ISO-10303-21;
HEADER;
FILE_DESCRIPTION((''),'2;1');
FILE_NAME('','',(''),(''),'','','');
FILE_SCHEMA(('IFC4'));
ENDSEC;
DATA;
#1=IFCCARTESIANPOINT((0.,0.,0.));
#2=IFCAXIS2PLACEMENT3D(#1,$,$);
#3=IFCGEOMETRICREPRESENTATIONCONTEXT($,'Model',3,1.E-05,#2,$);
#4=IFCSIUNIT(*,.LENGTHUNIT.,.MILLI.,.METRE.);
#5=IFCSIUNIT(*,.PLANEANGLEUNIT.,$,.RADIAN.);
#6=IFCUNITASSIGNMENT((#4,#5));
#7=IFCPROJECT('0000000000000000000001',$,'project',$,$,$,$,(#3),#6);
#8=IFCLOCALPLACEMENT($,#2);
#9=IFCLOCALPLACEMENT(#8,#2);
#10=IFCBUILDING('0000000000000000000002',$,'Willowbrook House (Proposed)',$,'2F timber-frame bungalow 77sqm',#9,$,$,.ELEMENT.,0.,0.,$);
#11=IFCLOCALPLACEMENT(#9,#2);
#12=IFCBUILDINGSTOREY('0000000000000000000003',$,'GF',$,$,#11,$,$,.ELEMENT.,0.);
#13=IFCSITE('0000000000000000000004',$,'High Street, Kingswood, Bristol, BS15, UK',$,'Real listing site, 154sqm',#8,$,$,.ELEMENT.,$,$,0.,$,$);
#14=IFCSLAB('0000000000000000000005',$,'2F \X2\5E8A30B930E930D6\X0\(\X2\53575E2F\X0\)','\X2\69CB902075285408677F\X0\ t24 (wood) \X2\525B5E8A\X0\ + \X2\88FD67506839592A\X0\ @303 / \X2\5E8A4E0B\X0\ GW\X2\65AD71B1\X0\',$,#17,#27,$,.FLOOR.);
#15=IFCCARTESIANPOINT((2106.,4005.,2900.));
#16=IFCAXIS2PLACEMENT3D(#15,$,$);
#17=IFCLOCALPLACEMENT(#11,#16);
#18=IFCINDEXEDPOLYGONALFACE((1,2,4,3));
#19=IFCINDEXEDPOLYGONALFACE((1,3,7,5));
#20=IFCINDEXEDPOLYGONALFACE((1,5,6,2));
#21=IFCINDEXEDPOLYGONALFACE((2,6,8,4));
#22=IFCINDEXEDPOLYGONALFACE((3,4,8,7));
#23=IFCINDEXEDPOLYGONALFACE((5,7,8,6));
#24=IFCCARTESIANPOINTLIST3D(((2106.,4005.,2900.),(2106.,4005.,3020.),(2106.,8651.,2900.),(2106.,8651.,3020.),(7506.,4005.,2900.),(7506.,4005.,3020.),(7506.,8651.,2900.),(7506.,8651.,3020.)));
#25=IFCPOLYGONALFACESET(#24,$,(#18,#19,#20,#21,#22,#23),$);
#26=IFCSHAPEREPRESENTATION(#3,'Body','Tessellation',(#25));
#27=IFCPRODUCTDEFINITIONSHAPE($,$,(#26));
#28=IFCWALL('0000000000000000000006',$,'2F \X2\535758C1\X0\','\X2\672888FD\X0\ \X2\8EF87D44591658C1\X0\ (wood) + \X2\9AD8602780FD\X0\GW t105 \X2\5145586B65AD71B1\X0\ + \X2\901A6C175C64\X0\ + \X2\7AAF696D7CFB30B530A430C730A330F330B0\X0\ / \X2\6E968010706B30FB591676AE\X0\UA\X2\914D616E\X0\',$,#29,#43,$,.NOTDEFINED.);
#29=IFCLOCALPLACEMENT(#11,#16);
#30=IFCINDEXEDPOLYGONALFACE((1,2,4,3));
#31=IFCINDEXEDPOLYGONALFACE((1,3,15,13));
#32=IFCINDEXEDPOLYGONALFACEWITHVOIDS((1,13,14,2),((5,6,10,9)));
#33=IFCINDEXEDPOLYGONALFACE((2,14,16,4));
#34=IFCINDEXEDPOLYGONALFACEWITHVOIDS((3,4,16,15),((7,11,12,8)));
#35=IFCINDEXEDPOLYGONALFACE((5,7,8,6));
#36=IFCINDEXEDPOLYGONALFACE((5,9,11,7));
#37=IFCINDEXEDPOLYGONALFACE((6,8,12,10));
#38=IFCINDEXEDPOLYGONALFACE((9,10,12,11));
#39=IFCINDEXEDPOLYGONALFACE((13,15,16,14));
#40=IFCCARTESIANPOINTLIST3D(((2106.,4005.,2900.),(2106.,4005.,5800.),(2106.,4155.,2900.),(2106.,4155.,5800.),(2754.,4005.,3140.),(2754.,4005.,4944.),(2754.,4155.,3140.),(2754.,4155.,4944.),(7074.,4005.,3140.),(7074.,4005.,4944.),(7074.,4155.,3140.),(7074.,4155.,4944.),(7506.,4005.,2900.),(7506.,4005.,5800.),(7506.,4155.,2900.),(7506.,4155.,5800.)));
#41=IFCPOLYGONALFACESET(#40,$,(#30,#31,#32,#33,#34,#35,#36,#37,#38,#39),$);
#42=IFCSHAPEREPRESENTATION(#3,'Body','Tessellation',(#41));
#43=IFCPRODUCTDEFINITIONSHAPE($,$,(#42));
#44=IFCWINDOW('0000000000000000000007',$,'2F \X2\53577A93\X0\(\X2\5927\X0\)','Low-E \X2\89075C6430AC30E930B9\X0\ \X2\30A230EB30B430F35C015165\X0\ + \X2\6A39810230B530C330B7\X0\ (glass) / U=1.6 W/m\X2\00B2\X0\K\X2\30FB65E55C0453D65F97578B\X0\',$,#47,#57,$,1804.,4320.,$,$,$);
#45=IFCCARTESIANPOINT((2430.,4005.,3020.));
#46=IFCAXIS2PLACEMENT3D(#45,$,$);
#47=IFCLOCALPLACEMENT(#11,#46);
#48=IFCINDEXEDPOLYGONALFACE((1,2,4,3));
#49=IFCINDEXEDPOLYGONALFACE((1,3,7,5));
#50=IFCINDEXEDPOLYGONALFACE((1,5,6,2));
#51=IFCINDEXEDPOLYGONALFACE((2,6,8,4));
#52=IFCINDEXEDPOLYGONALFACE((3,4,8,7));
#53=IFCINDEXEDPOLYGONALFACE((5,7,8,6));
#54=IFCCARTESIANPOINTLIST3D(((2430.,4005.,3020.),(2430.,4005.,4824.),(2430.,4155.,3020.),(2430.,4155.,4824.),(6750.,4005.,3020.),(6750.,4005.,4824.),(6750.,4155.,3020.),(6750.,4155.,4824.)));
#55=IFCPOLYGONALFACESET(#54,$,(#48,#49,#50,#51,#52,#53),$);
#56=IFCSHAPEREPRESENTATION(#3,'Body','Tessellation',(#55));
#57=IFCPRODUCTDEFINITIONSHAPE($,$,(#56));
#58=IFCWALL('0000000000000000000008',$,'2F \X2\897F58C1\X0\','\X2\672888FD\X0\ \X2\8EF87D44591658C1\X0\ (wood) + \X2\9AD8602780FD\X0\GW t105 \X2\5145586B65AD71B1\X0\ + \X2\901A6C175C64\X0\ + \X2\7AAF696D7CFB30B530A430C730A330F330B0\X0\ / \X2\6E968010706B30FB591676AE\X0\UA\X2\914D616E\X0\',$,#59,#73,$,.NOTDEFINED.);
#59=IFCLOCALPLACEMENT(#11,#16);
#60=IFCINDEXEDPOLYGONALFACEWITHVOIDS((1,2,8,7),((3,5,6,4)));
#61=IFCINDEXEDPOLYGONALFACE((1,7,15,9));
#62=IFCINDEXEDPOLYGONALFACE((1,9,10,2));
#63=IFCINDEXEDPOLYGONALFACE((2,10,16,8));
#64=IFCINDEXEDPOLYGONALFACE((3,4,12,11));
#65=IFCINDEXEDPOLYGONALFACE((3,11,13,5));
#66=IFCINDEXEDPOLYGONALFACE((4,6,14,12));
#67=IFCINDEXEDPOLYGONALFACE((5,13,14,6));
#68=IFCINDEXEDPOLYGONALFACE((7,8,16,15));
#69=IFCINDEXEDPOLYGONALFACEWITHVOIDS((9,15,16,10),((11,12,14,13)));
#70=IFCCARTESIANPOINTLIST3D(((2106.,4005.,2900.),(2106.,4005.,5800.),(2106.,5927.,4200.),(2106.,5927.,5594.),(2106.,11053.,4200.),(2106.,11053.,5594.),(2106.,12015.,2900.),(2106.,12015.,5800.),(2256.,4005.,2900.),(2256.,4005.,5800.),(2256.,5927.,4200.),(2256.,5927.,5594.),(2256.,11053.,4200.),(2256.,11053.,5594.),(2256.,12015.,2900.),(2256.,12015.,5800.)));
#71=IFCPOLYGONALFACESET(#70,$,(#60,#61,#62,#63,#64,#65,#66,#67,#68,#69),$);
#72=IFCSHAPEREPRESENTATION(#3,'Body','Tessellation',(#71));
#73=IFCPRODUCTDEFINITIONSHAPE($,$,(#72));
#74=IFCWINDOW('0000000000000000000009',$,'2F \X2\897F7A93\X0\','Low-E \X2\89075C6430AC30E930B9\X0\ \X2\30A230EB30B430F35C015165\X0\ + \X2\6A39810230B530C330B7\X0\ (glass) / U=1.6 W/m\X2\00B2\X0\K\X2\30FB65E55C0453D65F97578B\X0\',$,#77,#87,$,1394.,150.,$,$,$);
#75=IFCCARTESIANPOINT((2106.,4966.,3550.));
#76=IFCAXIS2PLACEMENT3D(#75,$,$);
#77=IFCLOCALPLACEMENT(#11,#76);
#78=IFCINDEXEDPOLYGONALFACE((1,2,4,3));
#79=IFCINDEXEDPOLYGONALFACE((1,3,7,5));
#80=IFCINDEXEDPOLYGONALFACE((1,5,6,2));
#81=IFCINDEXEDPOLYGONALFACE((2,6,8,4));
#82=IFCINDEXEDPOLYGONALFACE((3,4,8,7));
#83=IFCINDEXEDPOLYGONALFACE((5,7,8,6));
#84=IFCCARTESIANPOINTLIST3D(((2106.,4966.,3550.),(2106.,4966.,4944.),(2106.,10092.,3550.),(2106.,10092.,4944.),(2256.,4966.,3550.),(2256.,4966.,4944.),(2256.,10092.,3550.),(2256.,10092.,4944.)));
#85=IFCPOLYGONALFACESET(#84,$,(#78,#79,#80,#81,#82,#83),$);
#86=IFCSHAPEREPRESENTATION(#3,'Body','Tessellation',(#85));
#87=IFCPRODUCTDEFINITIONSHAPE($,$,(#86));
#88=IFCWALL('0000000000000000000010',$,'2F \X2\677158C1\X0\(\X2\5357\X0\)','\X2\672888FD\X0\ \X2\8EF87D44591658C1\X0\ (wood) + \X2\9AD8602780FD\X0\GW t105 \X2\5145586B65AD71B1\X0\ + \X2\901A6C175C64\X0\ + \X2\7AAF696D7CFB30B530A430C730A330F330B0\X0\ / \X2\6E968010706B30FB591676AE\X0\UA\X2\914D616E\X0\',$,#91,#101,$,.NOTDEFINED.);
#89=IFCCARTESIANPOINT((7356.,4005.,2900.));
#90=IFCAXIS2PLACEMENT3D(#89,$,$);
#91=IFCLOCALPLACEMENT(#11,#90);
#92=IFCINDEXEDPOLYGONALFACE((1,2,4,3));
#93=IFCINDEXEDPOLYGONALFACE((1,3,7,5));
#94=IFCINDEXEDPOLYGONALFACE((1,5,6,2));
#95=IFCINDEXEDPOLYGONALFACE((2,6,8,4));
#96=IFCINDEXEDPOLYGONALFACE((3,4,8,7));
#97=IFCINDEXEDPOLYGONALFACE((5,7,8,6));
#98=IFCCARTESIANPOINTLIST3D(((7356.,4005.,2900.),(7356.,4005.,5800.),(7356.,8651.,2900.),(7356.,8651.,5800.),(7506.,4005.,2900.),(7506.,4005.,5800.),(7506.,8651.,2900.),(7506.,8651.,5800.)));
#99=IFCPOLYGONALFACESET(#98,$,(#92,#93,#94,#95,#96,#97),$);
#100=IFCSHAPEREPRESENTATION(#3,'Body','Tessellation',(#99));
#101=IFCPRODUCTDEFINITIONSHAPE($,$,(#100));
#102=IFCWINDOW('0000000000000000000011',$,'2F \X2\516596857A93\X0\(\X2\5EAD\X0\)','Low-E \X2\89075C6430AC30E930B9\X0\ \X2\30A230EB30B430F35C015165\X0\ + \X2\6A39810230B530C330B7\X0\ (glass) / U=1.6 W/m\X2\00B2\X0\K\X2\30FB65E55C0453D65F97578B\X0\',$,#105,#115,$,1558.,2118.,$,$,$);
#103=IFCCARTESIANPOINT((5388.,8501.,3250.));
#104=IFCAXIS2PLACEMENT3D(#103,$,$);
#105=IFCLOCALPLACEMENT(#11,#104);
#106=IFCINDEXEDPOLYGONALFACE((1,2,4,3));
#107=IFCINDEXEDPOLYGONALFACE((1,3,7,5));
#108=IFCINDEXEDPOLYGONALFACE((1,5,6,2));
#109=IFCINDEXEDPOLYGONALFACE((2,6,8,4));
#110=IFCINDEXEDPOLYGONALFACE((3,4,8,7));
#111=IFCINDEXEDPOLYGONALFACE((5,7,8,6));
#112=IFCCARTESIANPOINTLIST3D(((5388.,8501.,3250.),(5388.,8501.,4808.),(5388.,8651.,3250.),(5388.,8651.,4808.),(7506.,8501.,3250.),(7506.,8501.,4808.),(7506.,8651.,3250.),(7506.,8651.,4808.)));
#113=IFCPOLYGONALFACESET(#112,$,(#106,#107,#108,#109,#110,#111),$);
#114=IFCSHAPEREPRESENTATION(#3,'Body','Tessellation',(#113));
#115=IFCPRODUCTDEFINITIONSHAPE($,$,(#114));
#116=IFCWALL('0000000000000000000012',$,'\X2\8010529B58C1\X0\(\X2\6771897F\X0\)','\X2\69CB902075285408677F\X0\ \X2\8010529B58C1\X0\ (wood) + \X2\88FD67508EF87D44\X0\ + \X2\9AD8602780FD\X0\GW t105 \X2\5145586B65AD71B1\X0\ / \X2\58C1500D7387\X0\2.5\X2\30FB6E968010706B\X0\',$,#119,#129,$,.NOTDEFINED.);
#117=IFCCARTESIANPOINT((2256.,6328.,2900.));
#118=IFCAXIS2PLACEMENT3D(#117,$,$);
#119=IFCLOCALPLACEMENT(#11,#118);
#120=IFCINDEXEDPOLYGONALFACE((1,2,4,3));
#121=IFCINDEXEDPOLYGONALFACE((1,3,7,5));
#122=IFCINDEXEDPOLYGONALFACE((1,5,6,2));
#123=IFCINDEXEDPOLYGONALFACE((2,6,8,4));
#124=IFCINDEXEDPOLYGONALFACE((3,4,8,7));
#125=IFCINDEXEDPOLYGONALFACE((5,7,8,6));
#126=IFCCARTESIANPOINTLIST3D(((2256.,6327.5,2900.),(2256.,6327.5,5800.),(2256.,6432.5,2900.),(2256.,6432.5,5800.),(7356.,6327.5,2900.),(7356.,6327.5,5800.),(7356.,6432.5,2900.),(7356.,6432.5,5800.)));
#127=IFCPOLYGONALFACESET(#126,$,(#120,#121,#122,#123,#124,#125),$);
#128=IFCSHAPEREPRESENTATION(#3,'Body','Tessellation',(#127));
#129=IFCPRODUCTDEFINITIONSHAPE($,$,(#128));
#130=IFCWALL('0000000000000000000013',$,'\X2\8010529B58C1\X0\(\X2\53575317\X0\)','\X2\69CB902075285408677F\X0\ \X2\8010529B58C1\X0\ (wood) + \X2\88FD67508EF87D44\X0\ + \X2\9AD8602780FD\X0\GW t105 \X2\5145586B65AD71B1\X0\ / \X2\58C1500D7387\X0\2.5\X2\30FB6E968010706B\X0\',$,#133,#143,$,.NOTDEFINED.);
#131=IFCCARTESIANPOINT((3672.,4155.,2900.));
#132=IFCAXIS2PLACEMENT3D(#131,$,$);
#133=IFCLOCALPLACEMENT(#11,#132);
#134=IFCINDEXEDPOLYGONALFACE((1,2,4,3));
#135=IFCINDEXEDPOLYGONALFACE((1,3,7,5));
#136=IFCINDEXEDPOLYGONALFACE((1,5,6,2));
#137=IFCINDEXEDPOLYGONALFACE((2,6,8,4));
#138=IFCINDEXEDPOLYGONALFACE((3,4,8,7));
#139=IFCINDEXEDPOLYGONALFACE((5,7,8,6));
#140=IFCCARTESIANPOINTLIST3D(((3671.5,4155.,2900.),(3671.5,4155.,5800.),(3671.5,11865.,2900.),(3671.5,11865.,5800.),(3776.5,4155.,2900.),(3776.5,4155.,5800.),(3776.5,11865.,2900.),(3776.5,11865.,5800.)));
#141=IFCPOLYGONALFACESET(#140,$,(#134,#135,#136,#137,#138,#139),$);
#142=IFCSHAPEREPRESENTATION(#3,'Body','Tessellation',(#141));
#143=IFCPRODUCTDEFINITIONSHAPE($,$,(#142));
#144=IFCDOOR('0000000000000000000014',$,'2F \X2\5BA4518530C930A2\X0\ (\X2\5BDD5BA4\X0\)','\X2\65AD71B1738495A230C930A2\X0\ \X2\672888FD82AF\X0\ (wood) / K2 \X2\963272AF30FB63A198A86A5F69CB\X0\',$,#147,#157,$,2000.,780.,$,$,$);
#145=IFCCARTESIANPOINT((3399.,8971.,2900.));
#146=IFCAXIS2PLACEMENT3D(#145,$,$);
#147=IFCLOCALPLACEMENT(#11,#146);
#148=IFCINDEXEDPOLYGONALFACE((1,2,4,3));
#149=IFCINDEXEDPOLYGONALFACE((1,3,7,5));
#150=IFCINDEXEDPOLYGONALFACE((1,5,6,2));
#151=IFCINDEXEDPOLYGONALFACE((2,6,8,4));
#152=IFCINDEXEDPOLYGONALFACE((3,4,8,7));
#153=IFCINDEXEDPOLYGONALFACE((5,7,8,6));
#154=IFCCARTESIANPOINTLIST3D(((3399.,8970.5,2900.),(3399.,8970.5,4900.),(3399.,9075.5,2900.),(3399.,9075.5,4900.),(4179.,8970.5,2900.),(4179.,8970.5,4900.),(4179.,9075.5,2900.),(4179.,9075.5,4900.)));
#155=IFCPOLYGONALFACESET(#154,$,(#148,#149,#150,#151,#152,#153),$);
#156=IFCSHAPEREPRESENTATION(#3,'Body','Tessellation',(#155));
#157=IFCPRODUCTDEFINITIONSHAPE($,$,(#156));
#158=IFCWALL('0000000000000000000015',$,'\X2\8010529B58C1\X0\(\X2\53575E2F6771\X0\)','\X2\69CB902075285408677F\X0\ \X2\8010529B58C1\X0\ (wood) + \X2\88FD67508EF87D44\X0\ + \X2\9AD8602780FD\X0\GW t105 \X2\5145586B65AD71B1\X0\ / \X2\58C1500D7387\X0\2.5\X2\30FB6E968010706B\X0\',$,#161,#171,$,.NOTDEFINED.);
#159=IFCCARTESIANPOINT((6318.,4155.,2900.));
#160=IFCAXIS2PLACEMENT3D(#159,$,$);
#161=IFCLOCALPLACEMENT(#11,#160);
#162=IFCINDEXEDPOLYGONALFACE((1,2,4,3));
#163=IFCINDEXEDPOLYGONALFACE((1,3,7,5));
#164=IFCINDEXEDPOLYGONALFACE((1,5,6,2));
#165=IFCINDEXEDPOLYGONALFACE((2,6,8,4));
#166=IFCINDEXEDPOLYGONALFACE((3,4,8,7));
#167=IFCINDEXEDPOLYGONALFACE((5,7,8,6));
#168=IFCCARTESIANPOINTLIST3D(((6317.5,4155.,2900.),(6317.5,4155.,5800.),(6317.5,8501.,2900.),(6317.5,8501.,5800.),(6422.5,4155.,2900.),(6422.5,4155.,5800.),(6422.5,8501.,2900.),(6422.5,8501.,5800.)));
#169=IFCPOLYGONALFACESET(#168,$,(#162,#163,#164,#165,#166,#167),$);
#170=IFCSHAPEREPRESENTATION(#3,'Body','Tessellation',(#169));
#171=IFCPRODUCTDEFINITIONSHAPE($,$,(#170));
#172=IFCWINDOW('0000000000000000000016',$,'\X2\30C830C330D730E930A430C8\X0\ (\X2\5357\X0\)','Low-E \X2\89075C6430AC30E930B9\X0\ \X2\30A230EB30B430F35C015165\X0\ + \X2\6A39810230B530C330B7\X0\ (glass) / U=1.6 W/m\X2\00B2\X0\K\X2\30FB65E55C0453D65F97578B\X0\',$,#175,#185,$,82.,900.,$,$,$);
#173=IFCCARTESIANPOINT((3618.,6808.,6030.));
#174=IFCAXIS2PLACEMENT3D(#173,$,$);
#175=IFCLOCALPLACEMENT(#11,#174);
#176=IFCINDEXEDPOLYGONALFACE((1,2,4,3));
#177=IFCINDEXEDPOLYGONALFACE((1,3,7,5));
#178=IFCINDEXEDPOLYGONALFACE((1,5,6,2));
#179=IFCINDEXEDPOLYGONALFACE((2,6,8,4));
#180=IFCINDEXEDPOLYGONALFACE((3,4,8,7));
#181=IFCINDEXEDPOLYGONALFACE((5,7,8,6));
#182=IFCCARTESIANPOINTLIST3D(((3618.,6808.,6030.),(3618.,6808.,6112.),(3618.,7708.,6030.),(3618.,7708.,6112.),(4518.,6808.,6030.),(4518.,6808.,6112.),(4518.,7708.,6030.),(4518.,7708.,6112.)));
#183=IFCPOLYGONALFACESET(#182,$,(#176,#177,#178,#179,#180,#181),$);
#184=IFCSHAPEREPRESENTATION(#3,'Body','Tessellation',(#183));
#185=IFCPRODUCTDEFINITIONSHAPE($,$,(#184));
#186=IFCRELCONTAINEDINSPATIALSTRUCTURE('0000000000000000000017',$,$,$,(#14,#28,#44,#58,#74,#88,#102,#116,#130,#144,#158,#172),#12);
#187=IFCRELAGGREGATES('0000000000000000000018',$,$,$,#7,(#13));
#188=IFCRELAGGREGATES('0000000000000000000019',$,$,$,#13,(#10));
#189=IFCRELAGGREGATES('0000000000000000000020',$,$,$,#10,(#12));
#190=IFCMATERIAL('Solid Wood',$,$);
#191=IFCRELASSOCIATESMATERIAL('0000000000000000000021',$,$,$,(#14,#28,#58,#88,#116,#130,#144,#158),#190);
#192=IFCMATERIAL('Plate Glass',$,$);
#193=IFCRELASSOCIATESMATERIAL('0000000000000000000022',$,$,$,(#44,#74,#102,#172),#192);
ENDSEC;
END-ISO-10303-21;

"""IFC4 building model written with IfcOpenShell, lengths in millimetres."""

from ifc_helpers import new_model, si_unit, frame, frame_2d, origin, place, context, project, spatial, rectangle, extrude, material, element, fill, save


model = new_model("IFC4")

# Units and contexts
model_context = context("Model", 3, precision=1e-05, world=origin())
ifc_project = project(units=[si_unit("LENGTHUNIT", "METRE", prefix="MILLI"), si_unit("PLANEANGLEUNIT", "RADIAN")], contexts=[model_context])

# Site, building, storey
site_placement = place(None, origin())
site = spatial("IfcSite", under=ifc_project, at=site_placement, Name="High Street, Kingswood, Bristol, BS15, UK", ObjectType="Real listing site, 154sqm", CompositionType="ELEMENT", RefElevation=0.0)
building_placement = place(site_placement, origin())
building = spatial("IfcBuilding", under=site, at=building_placement, Name="Willowbrook House (Proposed)", ObjectType="2F timber-frame bungalow 77sqm", CompositionType="ELEMENT", ElevationOfRefHeight=0.0, ElevationOfTerrain=0.0)
storey_placement = place(building_placement, origin())
storey = spatial("IfcBuildingStorey", under=building, at=storey_placement, Name="GF", CompositionType="ELEMENT", Elevation=0.0)

# Slab
ifc_material_1 = material(Name="Solid Wood")
slab_placement = place(storey_placement, frame((2106.0, 4005.0, 2900.0)))
element("IfcSlab", 1, at=slab_placement, inside=storey, material=ifc_material_1, Name="2F 床スラブ(南帯)", Description="構造用合板 t24 (wood) 剛床 + 製材根太 @303 / 床下 GW断熱", PredefinedType="FLOOR", context=model_context, shape_type="SweptSolid", body=[
    extrude(rectangle(XDim=5400.0, YDim=4646.0, at=frame_2d((2700.0, 2323.0))), frame((2106.0, 4005.0, 2900.0)), (0.0, 0.0, 1.0), 120.0),
])

# Walls, openings, windows
wall_1_placement = place(storey_placement, frame((2106.0, 4005.0, 2900.0)))
wall_1 = element("IfcWall", 2, at=wall_1_placement, inside=storey, material=ifc_material_1, Name="2F 南壁", Description="木製 軸組外壁 (wood) + 高性能GW t105 充填断熱 + 通気層 + 窯業系サイディング / 準耐火・外皮UA配慮", PredefinedType="NOTDEFINED", context=model_context, shape_type="SweptSolid", body=[
    extrude(rectangle(XDim=5400.0, YDim=150.0, at=frame_2d((2700.0, 75.0))), frame((2106.0, 4005.0, 2900.0)), (0.0, 0.0, 1.0), 2900.0),
])
opening_1_placement = place(storey_placement, frame((2430.0, 4005.0, 3020.0)))
opening_1 = element("IfcOpeningElement", 3, at=opening_1_placement, cuts=wall_1, PredefinedType="NOTDEFINED", context=model_context, shape_type="SweptSolid", body=[
    extrude(rectangle(XDim=4320.0, YDim=150.0, at=frame_2d((2160.0, 75.0))), frame((2430.0, 4005.0, 3020.0)), (0.0, 0.0, 1.0), 1804.0),
])
ifc_material_2 = material(Name="Plate Glass")
window_1_placement = place(storey_placement, frame((2430.0, 4005.0, 3020.0)))
window_1 = element("IfcWindow", 4, at=window_1_placement, inside=storey, material=ifc_material_2, Name="2F 南窓(大)", Description="Low-E 複層ガラス アルゴン封入 + 樹脂サッシ (glass) / U=1.6 W/m²K・日射取得型", OverallHeight=1804.0, OverallWidth=4320.0, context=model_context, shape_type="SweptSolid", body=[
    extrude(rectangle(XDim=4320.0, YDim=150.0, at=frame_2d((2160.0, 75.0))), frame((2430.0, 4005.0, 3020.0)), (0.0, 0.0, 1.0), 1804.0),
])
fill(opening_1, window_1)
wall_2_placement = place(storey_placement, frame((2106.0, 4005.0, 2900.0)))
wall_2 = element("IfcWall", 5, at=wall_2_placement, inside=storey, material=ifc_material_1, Name="2F 西壁", Description="木製 軸組外壁 (wood) + 高性能GW t105 充填断熱 + 通気層 + 窯業系サイディング / 準耐火・外皮UA配慮", PredefinedType="NOTDEFINED", context=model_context, shape_type="SweptSolid", body=[
    extrude(rectangle(XDim=150.0, YDim=8010.0, at=frame_2d((75.0, 4005.0))), frame((2106.0, 4005.0, 2900.0)), (0.0, 0.0, 1.0), 2900.0),
])
opening_2_placement = place(storey_placement, frame((2106.0, 4966.0, 3550.0)))
opening_2 = element("IfcOpeningElement", 6, at=opening_2_placement, cuts=wall_2, PredefinedType="NOTDEFINED", context=model_context, shape_type="SweptSolid", body=[
    extrude(rectangle(XDim=150.0, YDim=5126.0, at=frame_2d((75.0, 2563.0))), frame((2106.0, 4966.0, 3550.0)), (0.0, 0.0, 1.0), 1394.0),
])
window_2_placement = place(storey_placement, frame((2106.0, 4966.0, 3550.0)))
window_2 = element("IfcWindow", 7, at=window_2_placement, inside=storey, material=ifc_material_2, Name="2F 西窓", Description="Low-E 複層ガラス アルゴン封入 + 樹脂サッシ (glass) / U=1.6 W/m²K・日射取得型", OverallHeight=1394.0, OverallWidth=150.0, context=model_context, shape_type="SweptSolid", body=[
    extrude(rectangle(XDim=150.0, YDim=5126.0, at=frame_2d((75.0, 2563.0))), frame((2106.0, 4966.0, 3550.0)), (0.0, 0.0, 1.0), 1394.0),
])
fill(opening_2, window_2)
wall_3_placement = place(storey_placement, frame((7356.0, 4005.0, 2900.0)))
wall_3 = element("IfcWall", 8, at=wall_3_placement, inside=storey, material=ifc_material_1, Name="2F 東壁(南)", Description="木製 軸組外壁 (wood) + 高性能GW t105 充填断熱 + 通気層 + 窯業系サイディング / 準耐火・外皮UA配慮", PredefinedType="NOTDEFINED", context=model_context, shape_type="SweptSolid", body=[
    extrude(rectangle(XDim=150.0, YDim=4646.0, at=frame_2d((75.0, 2323.0))), frame((7356.0, 4005.0, 2900.0)), (0.0, 0.0, 1.0), 2900.0),
])
opening_3_placement = place(storey_placement, frame((5388.0, 8501.0, 3250.0)))
opening_3 = element("IfcOpeningElement", 9, at=opening_3_placement, cuts=wall_3, PredefinedType="NOTDEFINED", context=model_context, shape_type="SweptSolid", body=[
    extrude(rectangle(XDim=2118.0, YDim=150.0, at=frame_2d((1059.0, 75.0))), frame((5388.0, 8501.0, 3250.0)), (0.0, 0.0, 1.0), 1558.0),
])
window_3_placement = place(storey_placement, frame((5388.0, 8501.0, 3250.0)))
window_3 = element("IfcWindow", 10, at=window_3_placement, inside=storey, material=ifc_material_2, Name="2F 入隅窓(庭)", Description="Low-E 複層ガラス アルゴン封入 + 樹脂サッシ (glass) / U=1.6 W/m²K・日射取得型", OverallHeight=1558.0, OverallWidth=2118.0, context=model_context, shape_type="SweptSolid", body=[
    extrude(rectangle(XDim=2118.0, YDim=150.0, at=frame_2d((1059.0, 75.0))), frame((5388.0, 8501.0, 3250.0)), (0.0, 0.0, 1.0), 1558.0),
])
fill(opening_3, window_3)

# Wall
wall_4_placement = place(storey_placement, frame((2256.0, 6328.0, 2900.0)))
element("IfcWall", 11, at=wall_4_placement, inside=storey, material=ifc_material_1, Name="耐力壁(東西)", Description="構造用合板 耐力壁 (wood) + 製材軸組 + 高性能GW t105 充填断熱 / 壁倍率2.5・準耐火", PredefinedType="NOTDEFINED", context=model_context, shape_type="SweptSolid", body=[
    extrude(rectangle(XDim=5100.0, YDim=105.0, at=frame_2d((2550.0, 52.0))), frame((2256.0, 6328.0, 2900.0)), (0.0, 0.0, 1.0), 2900.0),
])

# Wall, opening, door
wall_5_placement = place(storey_placement, frame((3672.0, 4155.0, 2900.0)))
wall_5 = element("IfcWall", 12, at=wall_5_placement, inside=storey, material=ifc_material_1, Name="耐力壁(南北)", Description="構造用合板 耐力壁 (wood) + 製材軸組 + 高性能GW t105 充填断熱 / 壁倍率2.5・準耐火", PredefinedType="NOTDEFINED", context=model_context, shape_type="SweptSolid", body=[
    extrude(rectangle(XDim=105.0, YDim=7710.0, at=frame_2d((52.0, 3855.0))), frame((3672.0, 4155.0, 2900.0)), (0.0, 0.0, 1.0), 2900.0),
])
opening_4_placement = place(storey_placement, frame((3399.0, 8971.0, 2900.0)))
opening_4 = element("IfcOpeningElement", 13, at=opening_4_placement, cuts=wall_5, PredefinedType="NOTDEFINED", context=model_context, shape_type="SweptSolid", body=[
    extrude(rectangle(XDim=780.0, YDim=105.0, at=frame_2d((390.0, 52.0))), frame((3399.0, 8971.0, 2900.0)), (0.0, 0.0, 1.0), 2000.0),
])
door_placement = place(storey_placement, frame((3399.0, 8971.0, 2900.0)))
door = element("IfcDoor", 14, at=door_placement, inside=storey, material=ifc_material_1, Name="2F 室内ドア (寝室)", Description="断熱玄関ドア 木製芯 (wood) / K2 防犯・採風機構", OverallHeight=2000.0, OverallWidth=780.0, context=model_context, shape_type="SweptSolid", body=[
    extrude(rectangle(XDim=780.0, YDim=105.0, at=frame_2d((390.0, 52.0))), frame((3399.0, 8971.0, 2900.0)), (0.0, 0.0, 1.0), 2000.0),
])
fill(opening_4, door)

# Wall
wall_6_placement = place(storey_placement, frame((6318.0, 4155.0, 2900.0)))
element("IfcWall", 15, at=wall_6_placement, inside=storey, material=ifc_material_1, Name="耐力壁(南帯東)", Description="構造用合板 耐力壁 (wood) + 製材軸組 + 高性能GW t105 充填断熱 / 壁倍率2.5・準耐火", PredefinedType="NOTDEFINED", context=model_context, shape_type="SweptSolid", body=[
    extrude(rectangle(XDim=105.0, YDim=4346.0, at=frame_2d((52.0, 2173.0))), frame((6318.0, 4155.0, 2900.0)), (0.0, 0.0, 1.0), 2900.0),
])

# Window
window_4_placement = place(storey_placement, frame((3618.0, 6808.0, 6030.0)))
element("IfcWindow", 16, at=window_4_placement, inside=storey, material=ifc_material_2, Name="トップライト (南)", Description="Low-E 複層ガラス アルゴン封入 + 樹脂サッシ (glass) / U=1.6 W/m²K・日射取得型", OverallHeight=82.0, OverallWidth=900.0, context=model_context, shape_type="SweptSolid", body=[
    extrude(rectangle(XDim=900.0, YDim=900.0, at=frame_2d((450.0, 450.0))), frame((3618.0, 6808.0, 6030.0)), (0.0, 0.0, 1.0), 82.0),
])

save(model, "model.ifc")
